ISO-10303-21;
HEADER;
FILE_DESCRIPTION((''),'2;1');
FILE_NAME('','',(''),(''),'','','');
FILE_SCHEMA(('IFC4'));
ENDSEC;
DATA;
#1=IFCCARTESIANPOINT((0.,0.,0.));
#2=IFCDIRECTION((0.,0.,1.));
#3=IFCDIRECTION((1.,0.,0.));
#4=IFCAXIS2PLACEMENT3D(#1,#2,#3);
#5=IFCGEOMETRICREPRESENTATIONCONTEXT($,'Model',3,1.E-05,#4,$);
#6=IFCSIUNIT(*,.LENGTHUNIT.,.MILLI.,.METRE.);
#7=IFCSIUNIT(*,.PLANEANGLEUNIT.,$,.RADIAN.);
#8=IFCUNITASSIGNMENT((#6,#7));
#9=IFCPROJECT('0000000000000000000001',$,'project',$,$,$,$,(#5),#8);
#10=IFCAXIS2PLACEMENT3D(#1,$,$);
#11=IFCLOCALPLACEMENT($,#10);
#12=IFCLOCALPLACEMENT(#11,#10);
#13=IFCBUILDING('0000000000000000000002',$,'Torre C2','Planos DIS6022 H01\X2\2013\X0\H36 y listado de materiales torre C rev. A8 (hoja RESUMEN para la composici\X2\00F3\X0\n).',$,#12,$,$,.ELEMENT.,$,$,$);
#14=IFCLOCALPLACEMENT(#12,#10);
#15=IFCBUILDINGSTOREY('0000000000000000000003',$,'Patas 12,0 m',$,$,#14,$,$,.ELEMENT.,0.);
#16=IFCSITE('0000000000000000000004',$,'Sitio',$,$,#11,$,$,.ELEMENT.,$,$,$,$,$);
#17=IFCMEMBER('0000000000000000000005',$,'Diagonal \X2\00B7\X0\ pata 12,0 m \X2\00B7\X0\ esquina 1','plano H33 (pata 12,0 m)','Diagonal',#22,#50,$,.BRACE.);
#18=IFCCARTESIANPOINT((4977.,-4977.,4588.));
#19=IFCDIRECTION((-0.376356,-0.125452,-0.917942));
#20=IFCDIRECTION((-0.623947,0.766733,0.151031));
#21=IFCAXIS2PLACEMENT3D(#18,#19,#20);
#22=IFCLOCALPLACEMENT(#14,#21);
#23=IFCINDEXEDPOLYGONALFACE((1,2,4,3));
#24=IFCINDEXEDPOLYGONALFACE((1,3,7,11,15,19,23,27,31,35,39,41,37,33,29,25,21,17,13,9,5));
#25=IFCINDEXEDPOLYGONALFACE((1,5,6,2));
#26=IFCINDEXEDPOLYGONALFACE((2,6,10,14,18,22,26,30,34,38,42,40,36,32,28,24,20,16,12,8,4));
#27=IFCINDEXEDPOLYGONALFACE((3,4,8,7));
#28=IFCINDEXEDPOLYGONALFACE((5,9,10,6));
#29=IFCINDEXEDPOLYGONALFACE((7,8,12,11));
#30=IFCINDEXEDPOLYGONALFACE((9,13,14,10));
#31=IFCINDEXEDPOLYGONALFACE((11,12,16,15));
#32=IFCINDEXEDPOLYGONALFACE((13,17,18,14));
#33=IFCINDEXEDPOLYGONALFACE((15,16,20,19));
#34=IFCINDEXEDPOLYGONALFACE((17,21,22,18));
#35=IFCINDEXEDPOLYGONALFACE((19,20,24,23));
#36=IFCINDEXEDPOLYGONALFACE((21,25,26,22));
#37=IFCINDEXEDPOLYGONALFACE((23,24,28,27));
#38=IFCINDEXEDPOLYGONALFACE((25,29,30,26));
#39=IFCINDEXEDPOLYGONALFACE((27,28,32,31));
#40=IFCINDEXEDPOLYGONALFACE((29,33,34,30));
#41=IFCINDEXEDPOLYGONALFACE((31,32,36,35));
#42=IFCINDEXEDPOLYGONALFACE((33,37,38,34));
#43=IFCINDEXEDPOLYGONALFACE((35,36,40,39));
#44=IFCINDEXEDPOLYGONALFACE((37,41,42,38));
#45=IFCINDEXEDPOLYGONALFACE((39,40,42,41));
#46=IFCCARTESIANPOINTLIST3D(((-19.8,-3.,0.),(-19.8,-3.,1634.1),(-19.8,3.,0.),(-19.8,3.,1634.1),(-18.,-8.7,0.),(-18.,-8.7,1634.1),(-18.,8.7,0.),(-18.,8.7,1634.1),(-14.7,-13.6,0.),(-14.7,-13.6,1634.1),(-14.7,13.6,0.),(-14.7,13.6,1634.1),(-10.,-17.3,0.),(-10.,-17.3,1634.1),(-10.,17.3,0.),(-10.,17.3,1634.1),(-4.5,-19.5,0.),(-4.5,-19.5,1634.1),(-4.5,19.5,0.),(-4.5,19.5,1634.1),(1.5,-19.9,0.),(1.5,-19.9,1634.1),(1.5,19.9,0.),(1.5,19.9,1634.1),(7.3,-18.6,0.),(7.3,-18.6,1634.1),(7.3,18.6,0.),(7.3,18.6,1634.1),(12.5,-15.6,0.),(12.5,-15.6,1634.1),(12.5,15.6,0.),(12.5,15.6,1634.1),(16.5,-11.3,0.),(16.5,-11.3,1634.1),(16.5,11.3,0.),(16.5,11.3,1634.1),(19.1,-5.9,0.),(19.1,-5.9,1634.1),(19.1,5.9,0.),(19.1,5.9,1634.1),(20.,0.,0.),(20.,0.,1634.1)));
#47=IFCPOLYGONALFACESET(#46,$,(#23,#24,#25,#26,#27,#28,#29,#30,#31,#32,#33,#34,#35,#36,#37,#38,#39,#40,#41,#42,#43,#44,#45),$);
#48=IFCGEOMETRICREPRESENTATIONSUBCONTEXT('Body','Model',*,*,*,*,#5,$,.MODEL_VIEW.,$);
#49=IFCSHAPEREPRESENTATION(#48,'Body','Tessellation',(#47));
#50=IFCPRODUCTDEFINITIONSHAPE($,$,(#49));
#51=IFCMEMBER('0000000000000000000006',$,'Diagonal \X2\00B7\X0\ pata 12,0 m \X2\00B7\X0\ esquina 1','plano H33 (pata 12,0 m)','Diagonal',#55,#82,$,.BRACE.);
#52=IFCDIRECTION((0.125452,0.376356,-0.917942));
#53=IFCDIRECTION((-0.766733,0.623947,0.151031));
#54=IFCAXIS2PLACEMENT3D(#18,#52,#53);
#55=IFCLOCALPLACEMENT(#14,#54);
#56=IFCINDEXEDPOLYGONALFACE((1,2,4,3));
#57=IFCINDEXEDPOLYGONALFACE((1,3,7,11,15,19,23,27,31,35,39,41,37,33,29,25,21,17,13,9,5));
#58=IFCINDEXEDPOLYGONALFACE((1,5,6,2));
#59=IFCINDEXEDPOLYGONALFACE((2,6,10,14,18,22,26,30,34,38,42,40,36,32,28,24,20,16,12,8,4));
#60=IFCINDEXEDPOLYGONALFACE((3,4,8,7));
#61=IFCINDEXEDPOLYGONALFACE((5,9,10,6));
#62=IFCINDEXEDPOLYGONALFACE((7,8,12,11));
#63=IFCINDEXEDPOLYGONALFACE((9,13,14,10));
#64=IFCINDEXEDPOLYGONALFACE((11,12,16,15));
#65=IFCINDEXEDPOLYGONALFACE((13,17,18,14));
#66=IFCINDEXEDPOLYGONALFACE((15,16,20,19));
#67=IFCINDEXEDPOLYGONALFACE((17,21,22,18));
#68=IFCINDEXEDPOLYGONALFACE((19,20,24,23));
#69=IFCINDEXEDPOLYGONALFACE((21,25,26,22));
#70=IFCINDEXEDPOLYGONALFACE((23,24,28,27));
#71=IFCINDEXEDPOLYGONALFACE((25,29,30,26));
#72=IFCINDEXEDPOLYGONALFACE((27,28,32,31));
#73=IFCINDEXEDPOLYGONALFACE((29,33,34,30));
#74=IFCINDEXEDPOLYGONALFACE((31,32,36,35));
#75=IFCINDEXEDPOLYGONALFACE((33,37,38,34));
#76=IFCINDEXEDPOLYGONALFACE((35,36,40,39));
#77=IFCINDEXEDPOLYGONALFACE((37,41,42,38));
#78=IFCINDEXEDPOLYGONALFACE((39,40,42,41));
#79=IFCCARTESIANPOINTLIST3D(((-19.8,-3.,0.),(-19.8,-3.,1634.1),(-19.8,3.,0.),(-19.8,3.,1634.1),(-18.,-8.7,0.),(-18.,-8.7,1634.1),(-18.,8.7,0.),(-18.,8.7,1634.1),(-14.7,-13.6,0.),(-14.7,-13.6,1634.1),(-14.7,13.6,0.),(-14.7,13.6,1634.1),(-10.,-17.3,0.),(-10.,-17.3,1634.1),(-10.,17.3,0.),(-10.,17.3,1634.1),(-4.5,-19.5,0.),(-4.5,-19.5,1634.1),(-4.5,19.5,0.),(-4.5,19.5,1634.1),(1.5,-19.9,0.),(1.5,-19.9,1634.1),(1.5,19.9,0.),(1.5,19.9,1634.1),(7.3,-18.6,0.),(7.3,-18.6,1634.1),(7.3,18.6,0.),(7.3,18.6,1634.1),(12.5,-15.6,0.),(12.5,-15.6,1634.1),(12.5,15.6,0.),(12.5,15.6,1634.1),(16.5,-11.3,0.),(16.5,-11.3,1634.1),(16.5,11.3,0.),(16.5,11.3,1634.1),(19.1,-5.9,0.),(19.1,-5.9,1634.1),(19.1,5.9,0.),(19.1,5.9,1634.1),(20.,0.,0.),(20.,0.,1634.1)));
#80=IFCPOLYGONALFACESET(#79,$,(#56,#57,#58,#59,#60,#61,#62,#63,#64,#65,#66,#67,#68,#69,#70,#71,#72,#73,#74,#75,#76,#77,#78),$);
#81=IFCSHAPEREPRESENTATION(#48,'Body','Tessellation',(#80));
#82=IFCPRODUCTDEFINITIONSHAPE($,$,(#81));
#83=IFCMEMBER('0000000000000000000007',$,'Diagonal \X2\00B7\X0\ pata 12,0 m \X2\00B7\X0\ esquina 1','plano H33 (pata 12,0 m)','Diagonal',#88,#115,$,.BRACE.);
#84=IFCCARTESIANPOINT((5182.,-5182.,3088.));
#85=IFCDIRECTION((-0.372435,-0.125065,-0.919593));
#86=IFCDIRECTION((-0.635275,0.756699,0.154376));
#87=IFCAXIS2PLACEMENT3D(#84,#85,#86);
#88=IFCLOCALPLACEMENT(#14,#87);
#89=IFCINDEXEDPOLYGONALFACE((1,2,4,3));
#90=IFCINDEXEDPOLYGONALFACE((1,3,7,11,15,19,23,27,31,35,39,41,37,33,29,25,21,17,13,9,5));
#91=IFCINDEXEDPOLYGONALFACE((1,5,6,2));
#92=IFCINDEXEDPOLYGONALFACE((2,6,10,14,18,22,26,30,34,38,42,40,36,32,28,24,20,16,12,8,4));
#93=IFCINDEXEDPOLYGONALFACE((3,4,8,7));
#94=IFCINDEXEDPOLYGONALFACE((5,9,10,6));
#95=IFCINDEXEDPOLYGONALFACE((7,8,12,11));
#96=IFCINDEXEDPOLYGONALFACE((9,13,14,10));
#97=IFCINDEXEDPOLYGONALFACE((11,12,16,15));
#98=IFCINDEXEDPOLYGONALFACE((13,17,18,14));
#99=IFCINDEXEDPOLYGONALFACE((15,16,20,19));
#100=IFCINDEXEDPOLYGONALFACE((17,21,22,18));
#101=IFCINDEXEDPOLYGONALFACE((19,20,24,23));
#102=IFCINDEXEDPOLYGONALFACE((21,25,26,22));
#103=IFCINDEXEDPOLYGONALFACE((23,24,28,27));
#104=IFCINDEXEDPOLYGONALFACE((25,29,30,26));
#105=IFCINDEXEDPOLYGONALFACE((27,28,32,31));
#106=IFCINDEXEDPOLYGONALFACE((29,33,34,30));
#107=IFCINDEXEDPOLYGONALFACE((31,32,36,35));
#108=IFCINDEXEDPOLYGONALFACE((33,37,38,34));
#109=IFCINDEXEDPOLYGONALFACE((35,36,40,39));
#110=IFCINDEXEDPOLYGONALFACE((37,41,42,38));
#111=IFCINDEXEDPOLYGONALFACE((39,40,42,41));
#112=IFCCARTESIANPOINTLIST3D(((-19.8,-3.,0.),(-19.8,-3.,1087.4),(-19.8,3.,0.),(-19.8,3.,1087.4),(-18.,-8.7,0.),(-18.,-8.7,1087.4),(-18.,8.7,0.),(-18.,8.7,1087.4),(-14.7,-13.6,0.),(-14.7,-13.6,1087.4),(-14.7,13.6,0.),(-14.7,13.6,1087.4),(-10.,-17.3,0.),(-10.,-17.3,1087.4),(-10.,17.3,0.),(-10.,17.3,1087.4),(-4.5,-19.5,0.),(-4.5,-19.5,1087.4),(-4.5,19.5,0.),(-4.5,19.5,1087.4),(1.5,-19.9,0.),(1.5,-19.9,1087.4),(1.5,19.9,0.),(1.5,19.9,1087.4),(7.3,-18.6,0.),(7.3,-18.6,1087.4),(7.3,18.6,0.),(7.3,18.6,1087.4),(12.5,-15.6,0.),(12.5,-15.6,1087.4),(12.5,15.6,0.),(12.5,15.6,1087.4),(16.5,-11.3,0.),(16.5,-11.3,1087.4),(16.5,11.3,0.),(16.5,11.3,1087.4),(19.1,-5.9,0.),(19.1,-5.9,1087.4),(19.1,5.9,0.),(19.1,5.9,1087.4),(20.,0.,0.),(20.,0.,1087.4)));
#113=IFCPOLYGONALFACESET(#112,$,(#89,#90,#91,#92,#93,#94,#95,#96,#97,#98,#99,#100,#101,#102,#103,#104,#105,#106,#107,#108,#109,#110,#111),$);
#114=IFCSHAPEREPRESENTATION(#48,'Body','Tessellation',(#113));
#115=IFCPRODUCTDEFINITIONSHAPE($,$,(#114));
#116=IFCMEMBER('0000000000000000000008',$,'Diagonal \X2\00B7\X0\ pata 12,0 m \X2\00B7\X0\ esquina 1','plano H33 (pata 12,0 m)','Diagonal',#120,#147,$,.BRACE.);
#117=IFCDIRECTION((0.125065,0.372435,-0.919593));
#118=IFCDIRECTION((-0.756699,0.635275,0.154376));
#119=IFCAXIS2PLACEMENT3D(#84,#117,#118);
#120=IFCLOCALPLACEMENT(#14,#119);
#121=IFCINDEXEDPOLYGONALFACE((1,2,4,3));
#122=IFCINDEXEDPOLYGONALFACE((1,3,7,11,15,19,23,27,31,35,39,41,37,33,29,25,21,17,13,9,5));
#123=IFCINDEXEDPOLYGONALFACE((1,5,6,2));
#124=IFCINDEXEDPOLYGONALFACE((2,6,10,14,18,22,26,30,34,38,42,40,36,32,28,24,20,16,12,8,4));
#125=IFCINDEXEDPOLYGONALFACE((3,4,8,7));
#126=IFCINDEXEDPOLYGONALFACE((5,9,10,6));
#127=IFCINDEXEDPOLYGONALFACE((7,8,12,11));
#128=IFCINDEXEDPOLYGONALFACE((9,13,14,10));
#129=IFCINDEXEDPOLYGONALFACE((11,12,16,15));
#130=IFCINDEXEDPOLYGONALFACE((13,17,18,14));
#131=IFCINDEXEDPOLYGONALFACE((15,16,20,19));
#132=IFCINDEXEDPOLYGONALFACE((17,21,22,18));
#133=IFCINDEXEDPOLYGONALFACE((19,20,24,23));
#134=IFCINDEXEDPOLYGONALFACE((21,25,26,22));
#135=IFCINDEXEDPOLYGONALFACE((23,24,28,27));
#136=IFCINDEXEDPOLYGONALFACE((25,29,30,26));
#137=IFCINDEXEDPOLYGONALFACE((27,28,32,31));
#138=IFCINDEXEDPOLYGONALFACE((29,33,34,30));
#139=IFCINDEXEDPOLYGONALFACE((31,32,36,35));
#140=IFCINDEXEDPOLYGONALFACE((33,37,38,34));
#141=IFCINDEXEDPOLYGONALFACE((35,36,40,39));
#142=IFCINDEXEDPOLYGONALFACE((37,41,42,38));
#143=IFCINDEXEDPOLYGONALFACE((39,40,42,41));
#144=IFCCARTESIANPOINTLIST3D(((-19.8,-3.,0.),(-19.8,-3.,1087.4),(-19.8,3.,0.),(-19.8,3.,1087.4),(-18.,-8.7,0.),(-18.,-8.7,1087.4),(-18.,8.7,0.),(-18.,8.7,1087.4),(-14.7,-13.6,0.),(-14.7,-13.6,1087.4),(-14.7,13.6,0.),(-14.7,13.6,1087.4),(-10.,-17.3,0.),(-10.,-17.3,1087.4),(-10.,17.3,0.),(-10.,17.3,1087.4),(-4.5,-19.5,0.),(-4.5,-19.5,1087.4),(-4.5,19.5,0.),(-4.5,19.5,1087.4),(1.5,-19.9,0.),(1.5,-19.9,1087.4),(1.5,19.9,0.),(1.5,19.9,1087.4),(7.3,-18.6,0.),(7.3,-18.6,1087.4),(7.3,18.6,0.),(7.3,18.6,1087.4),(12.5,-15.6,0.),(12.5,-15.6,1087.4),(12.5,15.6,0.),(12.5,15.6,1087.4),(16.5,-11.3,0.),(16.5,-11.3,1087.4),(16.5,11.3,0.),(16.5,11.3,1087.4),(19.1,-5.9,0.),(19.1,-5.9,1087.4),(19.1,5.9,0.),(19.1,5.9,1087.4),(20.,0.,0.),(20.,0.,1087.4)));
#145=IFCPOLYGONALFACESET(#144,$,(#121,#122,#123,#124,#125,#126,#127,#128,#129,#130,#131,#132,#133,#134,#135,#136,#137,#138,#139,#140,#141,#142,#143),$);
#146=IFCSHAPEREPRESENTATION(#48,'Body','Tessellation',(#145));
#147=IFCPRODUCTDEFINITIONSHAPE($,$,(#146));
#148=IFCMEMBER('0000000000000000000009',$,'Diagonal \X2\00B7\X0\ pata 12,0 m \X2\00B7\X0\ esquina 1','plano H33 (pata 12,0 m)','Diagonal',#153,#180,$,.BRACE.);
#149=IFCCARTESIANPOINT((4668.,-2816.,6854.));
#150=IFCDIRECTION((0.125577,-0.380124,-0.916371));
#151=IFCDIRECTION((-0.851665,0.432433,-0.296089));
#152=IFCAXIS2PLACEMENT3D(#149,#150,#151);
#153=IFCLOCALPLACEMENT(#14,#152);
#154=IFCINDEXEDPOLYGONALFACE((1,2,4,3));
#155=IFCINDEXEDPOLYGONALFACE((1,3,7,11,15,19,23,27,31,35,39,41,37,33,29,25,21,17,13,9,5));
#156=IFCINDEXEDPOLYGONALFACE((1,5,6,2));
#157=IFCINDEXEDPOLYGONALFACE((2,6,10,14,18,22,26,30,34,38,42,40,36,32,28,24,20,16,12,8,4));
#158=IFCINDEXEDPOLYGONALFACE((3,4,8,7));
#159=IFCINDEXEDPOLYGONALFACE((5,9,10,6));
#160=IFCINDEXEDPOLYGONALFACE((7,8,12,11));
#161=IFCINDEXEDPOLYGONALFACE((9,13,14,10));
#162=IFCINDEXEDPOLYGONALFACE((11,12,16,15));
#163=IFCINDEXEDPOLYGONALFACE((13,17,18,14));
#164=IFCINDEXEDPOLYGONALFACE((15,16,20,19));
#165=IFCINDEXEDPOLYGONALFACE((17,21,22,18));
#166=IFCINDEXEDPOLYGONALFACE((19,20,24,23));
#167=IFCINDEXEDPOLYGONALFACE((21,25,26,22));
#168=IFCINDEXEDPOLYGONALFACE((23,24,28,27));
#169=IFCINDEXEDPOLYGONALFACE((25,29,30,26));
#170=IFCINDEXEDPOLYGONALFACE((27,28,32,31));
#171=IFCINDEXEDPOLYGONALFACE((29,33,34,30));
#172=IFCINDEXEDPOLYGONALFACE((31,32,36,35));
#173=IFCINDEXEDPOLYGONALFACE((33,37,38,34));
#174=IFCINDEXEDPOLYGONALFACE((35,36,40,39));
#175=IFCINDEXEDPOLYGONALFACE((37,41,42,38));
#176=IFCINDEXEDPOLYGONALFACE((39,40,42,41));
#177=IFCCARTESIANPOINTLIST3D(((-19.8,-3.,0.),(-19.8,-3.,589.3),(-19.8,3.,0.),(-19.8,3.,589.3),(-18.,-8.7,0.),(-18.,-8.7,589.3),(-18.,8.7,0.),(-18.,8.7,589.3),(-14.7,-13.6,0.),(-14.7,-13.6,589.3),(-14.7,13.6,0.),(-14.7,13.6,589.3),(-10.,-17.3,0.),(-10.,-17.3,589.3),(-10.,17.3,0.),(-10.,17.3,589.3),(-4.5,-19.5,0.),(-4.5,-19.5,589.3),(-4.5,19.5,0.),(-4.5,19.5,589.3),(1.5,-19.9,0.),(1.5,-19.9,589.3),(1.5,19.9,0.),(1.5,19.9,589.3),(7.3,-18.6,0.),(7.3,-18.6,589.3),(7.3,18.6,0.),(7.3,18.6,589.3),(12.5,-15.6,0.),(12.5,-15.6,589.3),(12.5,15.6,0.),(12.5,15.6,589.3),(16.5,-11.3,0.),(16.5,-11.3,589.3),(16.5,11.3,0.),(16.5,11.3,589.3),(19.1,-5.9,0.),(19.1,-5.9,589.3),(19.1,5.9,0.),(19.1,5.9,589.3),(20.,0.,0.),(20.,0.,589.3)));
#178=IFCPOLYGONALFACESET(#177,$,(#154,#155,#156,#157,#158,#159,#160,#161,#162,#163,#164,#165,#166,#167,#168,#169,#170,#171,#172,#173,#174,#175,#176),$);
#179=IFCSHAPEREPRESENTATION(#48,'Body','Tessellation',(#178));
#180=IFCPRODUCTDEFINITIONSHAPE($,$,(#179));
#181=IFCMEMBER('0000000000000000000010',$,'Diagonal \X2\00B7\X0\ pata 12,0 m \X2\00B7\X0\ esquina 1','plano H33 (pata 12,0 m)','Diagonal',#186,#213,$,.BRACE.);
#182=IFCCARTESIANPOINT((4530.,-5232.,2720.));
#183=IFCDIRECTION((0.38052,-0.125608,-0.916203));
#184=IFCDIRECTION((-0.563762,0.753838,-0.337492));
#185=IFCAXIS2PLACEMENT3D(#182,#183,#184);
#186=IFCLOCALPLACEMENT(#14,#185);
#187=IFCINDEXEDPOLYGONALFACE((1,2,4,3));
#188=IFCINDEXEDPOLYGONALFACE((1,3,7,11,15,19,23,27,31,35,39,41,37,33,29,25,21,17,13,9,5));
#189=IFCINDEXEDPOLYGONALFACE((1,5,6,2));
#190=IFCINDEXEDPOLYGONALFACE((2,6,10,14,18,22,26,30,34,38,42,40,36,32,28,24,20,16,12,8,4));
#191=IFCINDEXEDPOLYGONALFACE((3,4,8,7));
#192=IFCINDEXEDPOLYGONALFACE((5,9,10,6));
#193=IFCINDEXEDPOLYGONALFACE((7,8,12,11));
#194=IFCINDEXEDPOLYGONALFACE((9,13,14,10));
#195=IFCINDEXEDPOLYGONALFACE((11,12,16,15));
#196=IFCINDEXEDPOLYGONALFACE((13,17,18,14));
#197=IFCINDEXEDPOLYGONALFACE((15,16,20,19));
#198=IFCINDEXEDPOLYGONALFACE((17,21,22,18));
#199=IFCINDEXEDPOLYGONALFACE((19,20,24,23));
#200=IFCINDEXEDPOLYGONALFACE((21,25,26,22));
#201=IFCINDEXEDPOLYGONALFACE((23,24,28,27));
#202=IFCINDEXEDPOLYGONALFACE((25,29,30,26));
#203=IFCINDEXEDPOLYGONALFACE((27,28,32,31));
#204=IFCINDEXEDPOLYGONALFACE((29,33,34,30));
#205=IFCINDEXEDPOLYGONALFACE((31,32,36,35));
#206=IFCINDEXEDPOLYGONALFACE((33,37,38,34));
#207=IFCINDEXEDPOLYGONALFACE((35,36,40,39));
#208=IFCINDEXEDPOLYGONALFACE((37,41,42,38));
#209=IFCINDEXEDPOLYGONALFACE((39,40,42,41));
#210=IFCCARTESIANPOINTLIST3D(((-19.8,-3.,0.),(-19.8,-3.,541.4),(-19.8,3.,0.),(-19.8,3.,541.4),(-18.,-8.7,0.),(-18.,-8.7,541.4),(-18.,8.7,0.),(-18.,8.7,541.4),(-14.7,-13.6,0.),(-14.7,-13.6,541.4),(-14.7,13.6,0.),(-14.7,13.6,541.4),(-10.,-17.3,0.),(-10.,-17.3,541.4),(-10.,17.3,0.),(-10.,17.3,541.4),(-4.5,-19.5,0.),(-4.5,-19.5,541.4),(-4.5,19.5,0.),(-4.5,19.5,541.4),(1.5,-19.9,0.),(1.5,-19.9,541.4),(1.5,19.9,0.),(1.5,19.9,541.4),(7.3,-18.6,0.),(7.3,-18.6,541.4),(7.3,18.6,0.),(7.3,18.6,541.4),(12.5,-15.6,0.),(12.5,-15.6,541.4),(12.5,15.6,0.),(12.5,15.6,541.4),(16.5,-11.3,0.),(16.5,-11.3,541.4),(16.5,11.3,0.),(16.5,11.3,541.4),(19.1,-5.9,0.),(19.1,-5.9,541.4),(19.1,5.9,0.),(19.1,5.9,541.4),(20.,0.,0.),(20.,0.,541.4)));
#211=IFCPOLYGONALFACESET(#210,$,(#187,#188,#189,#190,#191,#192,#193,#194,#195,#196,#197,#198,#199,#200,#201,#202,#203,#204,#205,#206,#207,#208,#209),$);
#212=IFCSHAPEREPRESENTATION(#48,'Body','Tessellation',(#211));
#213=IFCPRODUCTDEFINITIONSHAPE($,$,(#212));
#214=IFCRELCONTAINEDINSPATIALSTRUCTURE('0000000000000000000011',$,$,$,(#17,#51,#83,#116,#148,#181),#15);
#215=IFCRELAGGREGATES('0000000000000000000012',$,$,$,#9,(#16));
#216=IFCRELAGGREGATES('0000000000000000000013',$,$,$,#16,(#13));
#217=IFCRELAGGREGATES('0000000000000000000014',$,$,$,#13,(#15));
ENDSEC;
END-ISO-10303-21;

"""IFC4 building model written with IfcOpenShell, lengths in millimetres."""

from ifc_helpers import new_model, si_unit, frame, origin, origin_with_axes, place, context, subcontext, project, spatial, circle, extrude, element, save


model = new_model("IFC4")

# Units and contexts
model_context = context("Model", 3, precision=1e-05, world=origin_with_axes())
body_context = subcontext(model_context, "Body", "Model", "MODEL_VIEW")
ifc_project = project(units=[si_unit("LENGTHUNIT", "METRE", prefix="MILLI"), si_unit("PLANEANGLEUNIT", "RADIAN")], contexts=[model_context])

# Site, building, storey
site_placement = place(None, origin())
site = spatial("IfcSite", under=ifc_project, at=site_placement, Name="Sitio", CompositionType="ELEMENT")
building_placement = place(site_placement, origin())
building = spatial("IfcBuilding", under=site, at=building_placement, Name="Torre C2", Description="Planos DIS6022 H01–H36 y listado de materiales torre C rev. A8 (hoja RESUMEN para la composición).", CompositionType="ELEMENT")
storey_placement = place(building_placement, origin())
storey = spatial("IfcBuildingStorey", under=building, at=storey_placement, Name="Patas 12,0 m", CompositionType="ELEMENT", Elevation=0.0)

# Members
for number, where, z_axis, x_axis, name in (
    (1, (4977.0, -4977.0, 4588.0), (-0.376356, -0.125452, -0.917942), (-0.623947, 0.766733, 0.151031), "Diagonal · pata 12,0 m · esquina 1"),
    (2, (4977.0, -4977.0, 4588.0), (0.125452, 0.376356, -0.917942), (-0.766733, 0.623947, 0.151031), "Diagonal · pata 12,0 m · esquina 1"),
):
    element("IfcMember", number, at=place(storey_placement, frame(where, z_axis=z_axis, x_axis=x_axis)), inside=storey, Name=name, Description="plano H33 (pata 12,0 m)", ObjectType="Diagonal", PredefinedType="BRACE", context=body_context, shape_type="SweptSolid", body=[
        extrude(circle(Radius=20.0), None, (0.0, 0.0, 1.0), 1634.1),
    ])
for number, where, z_axis, x_axis, name in (
    (3, (5182.0, -5182.0, 3088.0), (-0.372435, -0.125065, -0.919593), (-0.635275, 0.756699, 0.154376), "Diagonal · pata 12,0 m · esquina 1"),
    (4, (5182.0, -5182.0, 3088.0), (0.125065, 0.372435, -0.919593), (-0.756699, 0.635275, 0.154376), "Diagonal · pata 12,0 m · esquina 1"),
):
    element("IfcMember", number, at=place(storey_placement, frame(where, z_axis=z_axis, x_axis=x_axis)), inside=storey, Name=name, Description="plano H33 (pata 12,0 m)", ObjectType="Diagonal", PredefinedType="BRACE", context=body_context, shape_type="SweptSolid", body=[
        extrude(circle(Radius=20.0), None, (0.0, 0.0, 1.0), 1087.4),
    ])
member_1_placement = place(storey_placement, frame((4668.0, -2816.0, 6854.0), z_axis=(0.125577, -0.380124, -0.916371), x_axis=(-0.851665, 0.432433, -0.296089)))
element("IfcMember", 5, at=member_1_placement, inside=storey, Name="Diagonal · pata 12,0 m · esquina 1", Description="plano H33 (pata 12,0 m)", ObjectType="Diagonal", PredefinedType="BRACE", context=body_context, shape_type="SweptSolid", body=[
    extrude(circle(Radius=20.0), None, (0.0, 0.0, 1.0), 589.3),
])
for number, where, z_axis, x_axis, name in (
    (6, (4530.0, -5232.0, 2720.0), (0.38052, -0.125608, -0.916203), (-0.563762, 0.753838, -0.337492), "Diagonal · pata 12,0 m · esquina 1"),
):
    element("IfcMember", number, at=place(storey_placement, frame(where, z_axis=z_axis, x_axis=x_axis)), inside=storey, Name=name, Description="plano H33 (pata 12,0 m)", ObjectType="Diagonal", PredefinedType="BRACE", context=body_context, shape_type="SweptSolid", body=[
        extrude(circle(Radius=20.0), None, (0.0, 0.0, 1.0), 541.4),
    ])

save(model, "model.ifc")
